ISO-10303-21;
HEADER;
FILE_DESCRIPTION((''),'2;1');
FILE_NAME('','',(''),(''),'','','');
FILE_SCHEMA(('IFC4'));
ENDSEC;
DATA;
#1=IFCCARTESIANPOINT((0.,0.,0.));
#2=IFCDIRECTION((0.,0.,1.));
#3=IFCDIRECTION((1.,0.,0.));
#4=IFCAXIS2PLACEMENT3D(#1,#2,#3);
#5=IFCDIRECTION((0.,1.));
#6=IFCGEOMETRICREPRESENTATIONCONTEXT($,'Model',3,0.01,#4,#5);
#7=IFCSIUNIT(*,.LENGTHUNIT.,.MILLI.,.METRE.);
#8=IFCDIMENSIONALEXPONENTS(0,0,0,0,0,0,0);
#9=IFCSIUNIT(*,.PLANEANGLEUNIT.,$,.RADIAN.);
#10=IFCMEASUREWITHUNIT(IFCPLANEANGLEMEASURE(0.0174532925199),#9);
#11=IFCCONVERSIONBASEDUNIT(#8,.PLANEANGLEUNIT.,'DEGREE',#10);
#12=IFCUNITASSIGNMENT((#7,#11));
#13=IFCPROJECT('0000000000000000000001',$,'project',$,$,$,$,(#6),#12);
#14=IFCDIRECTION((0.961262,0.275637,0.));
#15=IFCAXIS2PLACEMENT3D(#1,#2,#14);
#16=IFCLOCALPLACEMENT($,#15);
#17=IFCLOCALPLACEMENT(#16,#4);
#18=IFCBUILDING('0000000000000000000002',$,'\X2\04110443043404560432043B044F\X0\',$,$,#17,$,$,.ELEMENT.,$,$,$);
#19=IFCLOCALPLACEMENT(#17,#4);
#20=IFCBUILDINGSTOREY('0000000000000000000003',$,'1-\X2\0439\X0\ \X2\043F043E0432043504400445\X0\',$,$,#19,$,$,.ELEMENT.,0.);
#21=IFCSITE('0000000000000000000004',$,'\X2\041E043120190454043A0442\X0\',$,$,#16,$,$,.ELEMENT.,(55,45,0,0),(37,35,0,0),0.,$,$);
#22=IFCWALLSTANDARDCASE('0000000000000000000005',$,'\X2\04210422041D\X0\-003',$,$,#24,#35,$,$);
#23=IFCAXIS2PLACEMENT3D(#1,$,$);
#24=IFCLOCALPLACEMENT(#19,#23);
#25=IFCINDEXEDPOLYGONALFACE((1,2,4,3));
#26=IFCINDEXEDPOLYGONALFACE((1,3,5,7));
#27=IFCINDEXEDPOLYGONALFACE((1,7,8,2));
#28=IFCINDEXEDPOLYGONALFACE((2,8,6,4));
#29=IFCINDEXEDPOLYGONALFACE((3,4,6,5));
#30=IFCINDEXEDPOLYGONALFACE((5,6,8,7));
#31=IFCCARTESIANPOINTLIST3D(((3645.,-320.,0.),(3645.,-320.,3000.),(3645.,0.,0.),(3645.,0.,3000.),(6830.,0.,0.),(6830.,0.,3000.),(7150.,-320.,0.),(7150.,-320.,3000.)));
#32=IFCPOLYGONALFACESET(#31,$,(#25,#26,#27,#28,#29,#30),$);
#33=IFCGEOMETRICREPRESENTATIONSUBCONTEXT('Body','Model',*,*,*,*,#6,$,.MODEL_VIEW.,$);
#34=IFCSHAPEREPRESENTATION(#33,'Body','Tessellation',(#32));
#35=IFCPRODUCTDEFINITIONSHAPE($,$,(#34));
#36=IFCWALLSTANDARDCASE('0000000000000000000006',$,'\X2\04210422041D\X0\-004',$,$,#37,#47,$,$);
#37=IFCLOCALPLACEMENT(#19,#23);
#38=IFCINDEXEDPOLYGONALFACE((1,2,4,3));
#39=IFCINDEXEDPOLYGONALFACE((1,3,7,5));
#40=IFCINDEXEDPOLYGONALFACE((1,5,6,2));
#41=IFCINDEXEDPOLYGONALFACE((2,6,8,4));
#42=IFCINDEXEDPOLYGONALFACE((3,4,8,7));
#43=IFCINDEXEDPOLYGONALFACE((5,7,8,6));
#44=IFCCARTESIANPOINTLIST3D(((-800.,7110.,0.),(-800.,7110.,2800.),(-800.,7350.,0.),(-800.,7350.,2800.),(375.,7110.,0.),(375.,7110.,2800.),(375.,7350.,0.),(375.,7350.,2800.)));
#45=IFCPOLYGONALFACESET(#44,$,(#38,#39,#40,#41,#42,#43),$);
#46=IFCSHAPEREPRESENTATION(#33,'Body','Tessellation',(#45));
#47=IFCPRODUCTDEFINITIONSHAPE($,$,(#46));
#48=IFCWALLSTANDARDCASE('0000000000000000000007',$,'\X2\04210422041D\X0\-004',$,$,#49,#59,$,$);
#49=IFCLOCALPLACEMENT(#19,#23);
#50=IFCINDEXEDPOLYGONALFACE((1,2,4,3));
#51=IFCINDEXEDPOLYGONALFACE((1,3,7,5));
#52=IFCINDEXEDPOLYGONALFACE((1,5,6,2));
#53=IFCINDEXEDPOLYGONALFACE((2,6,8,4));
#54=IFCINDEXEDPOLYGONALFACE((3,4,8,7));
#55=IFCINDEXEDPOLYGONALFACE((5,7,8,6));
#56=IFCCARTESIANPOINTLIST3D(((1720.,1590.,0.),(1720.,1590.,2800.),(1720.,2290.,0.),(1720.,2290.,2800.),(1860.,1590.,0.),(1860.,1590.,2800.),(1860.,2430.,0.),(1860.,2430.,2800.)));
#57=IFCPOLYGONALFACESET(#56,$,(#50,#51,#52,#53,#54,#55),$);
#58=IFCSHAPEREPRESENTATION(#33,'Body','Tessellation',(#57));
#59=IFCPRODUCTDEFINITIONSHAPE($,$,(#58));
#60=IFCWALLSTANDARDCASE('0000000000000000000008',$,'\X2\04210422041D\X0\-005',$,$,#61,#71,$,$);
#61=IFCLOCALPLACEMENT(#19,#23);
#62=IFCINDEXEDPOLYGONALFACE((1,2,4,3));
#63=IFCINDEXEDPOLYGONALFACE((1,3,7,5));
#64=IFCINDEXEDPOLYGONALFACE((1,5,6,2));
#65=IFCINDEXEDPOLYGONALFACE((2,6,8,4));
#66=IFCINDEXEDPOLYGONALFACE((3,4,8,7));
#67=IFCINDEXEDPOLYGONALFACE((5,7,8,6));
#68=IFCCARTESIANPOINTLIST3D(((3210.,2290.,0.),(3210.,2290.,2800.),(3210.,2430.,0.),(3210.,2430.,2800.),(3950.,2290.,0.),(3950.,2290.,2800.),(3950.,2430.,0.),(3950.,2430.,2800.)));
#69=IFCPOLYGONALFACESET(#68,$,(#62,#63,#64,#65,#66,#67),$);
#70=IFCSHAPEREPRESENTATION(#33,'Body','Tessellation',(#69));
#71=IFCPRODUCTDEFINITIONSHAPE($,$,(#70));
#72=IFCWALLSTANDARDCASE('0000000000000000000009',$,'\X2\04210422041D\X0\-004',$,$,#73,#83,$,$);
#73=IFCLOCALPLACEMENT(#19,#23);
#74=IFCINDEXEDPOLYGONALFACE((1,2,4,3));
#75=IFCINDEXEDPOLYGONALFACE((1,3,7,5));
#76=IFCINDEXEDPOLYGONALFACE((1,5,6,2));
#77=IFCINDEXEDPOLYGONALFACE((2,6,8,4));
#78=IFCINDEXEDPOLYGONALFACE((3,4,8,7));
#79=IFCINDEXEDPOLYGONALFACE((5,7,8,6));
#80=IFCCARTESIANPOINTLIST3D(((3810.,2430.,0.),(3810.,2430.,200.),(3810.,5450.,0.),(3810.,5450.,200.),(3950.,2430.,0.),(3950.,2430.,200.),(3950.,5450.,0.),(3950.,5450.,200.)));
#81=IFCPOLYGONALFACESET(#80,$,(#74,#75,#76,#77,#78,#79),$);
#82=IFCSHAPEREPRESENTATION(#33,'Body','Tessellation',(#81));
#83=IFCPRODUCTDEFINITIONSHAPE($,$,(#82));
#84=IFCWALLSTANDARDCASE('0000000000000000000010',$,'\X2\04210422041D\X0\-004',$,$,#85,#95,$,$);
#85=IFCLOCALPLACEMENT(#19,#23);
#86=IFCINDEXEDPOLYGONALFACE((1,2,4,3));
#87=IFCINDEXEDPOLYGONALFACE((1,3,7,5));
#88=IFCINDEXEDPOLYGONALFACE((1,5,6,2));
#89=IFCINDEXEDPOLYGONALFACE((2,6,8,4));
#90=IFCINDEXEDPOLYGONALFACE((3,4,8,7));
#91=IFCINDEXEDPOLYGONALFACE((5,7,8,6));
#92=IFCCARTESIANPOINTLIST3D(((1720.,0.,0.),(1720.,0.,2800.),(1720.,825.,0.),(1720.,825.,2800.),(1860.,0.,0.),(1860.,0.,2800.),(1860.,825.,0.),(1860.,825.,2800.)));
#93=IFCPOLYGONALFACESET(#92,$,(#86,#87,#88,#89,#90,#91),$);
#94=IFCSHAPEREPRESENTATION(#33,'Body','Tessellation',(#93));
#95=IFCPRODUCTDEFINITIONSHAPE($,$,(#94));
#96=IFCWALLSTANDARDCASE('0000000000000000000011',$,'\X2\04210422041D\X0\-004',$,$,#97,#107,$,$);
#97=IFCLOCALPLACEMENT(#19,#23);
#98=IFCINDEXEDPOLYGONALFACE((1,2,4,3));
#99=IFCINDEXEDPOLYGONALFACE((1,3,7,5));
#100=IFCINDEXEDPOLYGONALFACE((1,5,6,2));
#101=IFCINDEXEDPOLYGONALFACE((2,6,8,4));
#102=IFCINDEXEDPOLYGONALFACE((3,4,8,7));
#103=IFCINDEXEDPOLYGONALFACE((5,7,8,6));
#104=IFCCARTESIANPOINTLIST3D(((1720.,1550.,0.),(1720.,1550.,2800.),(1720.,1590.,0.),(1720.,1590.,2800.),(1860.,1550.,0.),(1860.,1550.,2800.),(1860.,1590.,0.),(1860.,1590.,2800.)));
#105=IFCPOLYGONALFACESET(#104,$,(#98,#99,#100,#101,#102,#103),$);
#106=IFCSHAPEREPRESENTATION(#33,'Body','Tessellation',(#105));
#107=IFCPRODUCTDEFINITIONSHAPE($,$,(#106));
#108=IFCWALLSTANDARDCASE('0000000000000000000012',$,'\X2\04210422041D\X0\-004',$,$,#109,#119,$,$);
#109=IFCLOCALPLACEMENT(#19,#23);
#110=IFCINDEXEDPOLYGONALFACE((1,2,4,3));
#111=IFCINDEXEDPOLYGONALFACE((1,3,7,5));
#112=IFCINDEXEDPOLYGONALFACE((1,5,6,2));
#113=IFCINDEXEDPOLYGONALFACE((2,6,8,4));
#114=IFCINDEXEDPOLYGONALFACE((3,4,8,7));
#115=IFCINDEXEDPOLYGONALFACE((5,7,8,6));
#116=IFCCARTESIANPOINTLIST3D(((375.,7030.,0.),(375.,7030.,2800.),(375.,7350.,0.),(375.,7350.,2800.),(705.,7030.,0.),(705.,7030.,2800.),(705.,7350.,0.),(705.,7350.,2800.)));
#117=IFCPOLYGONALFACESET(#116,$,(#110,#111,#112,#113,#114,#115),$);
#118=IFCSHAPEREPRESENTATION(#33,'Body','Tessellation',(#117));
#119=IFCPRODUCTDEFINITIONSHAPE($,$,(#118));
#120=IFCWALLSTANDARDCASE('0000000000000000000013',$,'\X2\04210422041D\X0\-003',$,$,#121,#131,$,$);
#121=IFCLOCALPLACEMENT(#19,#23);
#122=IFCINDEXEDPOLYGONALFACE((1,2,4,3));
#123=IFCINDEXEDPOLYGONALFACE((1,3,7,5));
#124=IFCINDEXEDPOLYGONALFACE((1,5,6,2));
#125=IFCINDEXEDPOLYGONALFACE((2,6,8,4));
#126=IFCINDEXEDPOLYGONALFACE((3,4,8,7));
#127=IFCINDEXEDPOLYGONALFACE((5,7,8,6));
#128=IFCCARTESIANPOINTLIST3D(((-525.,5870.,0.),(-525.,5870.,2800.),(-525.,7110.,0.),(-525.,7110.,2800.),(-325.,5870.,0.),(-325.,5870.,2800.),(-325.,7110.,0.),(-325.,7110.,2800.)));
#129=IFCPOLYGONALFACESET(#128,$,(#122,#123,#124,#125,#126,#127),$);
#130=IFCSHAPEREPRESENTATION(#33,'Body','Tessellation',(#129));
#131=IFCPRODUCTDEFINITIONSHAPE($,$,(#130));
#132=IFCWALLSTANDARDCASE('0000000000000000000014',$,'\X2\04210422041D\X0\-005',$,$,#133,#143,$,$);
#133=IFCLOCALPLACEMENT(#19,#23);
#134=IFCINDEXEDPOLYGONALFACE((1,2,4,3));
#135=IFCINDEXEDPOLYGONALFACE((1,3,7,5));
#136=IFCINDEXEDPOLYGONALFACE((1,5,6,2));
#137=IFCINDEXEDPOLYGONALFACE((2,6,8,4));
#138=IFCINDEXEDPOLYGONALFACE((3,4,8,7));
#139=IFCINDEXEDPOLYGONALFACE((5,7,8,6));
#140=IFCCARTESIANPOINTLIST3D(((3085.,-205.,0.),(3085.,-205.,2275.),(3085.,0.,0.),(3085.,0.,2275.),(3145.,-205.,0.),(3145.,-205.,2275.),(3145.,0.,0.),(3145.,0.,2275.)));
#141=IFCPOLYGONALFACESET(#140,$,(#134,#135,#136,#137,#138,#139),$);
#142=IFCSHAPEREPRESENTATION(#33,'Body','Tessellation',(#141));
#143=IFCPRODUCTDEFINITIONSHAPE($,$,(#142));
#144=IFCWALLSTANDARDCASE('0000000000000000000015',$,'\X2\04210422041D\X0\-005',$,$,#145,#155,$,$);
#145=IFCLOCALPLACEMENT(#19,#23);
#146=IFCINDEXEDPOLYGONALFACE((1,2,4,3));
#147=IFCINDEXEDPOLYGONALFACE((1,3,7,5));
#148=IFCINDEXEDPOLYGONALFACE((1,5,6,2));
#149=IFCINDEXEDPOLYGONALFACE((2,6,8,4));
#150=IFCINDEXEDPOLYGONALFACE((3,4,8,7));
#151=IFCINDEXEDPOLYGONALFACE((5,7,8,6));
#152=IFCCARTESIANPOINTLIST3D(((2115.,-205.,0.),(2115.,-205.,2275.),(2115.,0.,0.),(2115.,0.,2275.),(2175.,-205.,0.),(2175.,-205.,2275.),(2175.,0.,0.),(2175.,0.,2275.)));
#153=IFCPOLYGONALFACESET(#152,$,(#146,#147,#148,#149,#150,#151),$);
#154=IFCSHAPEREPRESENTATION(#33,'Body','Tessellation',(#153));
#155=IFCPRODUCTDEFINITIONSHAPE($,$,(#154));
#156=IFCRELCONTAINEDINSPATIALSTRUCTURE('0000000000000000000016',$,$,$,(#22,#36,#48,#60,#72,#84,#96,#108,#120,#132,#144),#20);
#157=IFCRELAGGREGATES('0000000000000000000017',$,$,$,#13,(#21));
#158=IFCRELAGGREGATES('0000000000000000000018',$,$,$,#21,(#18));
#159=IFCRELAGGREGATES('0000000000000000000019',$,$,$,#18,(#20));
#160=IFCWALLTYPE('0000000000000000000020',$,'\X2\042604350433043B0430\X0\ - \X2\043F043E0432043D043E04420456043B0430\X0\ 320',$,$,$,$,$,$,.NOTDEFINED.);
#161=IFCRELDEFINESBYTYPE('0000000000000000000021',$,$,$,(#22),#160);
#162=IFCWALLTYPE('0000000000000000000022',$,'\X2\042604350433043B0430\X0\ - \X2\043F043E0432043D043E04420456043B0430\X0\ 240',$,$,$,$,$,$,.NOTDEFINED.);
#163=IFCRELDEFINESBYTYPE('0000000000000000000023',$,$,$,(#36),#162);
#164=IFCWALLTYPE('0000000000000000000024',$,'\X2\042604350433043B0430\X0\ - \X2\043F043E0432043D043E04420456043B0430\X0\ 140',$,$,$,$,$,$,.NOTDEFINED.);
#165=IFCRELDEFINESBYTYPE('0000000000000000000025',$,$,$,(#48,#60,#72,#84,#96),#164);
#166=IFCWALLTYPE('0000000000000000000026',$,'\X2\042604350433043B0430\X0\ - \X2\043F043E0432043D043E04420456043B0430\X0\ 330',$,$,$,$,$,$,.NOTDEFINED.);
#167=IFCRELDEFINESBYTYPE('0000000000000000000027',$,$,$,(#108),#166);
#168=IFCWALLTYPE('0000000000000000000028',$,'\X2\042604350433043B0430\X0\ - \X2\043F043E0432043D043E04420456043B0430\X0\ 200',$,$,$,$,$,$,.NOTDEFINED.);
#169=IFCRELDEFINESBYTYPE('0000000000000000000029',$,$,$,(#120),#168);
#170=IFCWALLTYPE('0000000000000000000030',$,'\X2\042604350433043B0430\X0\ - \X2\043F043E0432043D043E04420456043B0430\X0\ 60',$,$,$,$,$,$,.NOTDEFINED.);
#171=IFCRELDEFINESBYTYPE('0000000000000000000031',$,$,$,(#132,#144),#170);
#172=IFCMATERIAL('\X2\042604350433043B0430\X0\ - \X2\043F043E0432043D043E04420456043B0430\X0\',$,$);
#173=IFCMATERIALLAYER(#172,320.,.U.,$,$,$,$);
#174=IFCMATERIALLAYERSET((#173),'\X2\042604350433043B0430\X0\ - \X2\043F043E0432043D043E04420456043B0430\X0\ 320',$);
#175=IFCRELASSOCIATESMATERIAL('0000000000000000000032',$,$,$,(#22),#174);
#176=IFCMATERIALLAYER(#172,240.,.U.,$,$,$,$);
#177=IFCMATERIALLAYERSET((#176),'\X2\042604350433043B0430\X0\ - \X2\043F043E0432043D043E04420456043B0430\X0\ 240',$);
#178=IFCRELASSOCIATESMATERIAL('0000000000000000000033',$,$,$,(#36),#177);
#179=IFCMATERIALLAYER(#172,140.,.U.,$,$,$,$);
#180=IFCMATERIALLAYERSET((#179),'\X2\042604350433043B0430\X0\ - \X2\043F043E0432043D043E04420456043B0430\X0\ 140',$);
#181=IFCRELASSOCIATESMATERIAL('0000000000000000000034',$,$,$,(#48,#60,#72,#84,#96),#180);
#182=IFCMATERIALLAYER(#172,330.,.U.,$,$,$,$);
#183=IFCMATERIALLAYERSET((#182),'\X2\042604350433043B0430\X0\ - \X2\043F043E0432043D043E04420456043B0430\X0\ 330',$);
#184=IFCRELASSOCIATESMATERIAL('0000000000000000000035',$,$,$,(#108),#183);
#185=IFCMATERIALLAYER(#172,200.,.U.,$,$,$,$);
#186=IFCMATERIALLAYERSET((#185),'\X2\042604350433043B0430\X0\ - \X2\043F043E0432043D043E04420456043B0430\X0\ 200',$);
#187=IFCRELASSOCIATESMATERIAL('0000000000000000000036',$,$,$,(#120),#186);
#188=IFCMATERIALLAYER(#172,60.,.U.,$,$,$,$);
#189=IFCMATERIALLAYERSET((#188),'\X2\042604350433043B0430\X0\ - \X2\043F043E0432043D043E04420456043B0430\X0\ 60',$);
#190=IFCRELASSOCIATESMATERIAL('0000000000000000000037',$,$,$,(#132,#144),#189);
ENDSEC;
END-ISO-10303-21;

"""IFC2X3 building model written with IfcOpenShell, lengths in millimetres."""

from ifc_helpers import new_model, entity, si_unit, converted_unit, direction, frame, origin_with_axes, place, context, subcontext, project, spatial, polyline, outline, extrude, material, layer, layer_set, layer_usage, type_object, element, save


model = new_model("IFC2X3")

# Units and contexts
model_context = context("Model", 3, precision=0.01, world=origin_with_axes(), true_north=direction((0.0, 1.0)))
body_context = subcontext(model_context, "Body", "Model", "MODEL_VIEW")
ifc_project = project(units=[si_unit("LENGTHUNIT", "METRE", prefix="MILLI"), converted_unit("PLANEANGLEUNIT", "DEGREE", entity("IfcPlaneAngleMeasure", 0.0174532925199), si_unit("PLANEANGLEUNIT", "RADIAN"), dimensions=[0, 0, 0, 0, 0, 0, 0])], contexts=[model_context])

# Site, building, storey
site_placement = place(None, frame((0.0, 0.0, 0.0), z_axis=(0.0, 0.0, 1.0), x_axis=(0.961262, 0.275637, 0.0)))
site = spatial("IfcSite", under=ifc_project, at=site_placement, Name="Об’єкт", CompositionType="ELEMENT", RefLatitude=(55, 45, 0, 0), RefLongitude=(37, 35, 0, 0), RefElevation=0.0)
building_placement = place(site_placement, origin_with_axes())
building = spatial("IfcBuilding", under=site, at=building_placement, Name="Будівля", CompositionType="ELEMENT")
storey_placement = place(building_placement, origin_with_axes())
storey = spatial("IfcBuildingStorey", under=building, at=storey_placement, Name="1-й поверх", CompositionType="ELEMENT", Elevation=0.0)

# Walls
ifc_material_1 = material(Name="Цегла - повнотіла")
ifc_layer_1 = layer(ifc_material_1, 320.0, ventilated="UNKNOWN")
ifc_layer_set_1 = layer_set([ifc_layer_1], Name="Цегла - повнотіла 320")
wall_type_1 = type_object("IfcWallType", Name="Цегла - повнотіла 320", PredefinedType="NOTDEFINED")
ifc_layer_usage_1 = layer_usage(ifc_layer_set_1, "AXIS2", "POSITIVE", 0.0)
wall_1_placement = place(storey_placement, frame((3645.0, -320.0, 0.0), z_axis=(0.0, 0.0, 1.0), x_axis=(1.0, 0.0, 0.0)))
element("IfcWallStandardCase", 1, at=wall_1_placement, inside=storey, type_object=wall_type_1, material=ifc_layer_usage_1, Name="СТН-003", context=body_context, shape_type="SweptSolid", body=[
    extrude(outline(polyline([(0.0, 0.0), (3505.0, 0.0), (3185.0, 320.0), (0.0, 320.0), (0.0, 0.0)])), origin_with_axes(), (0.0, 0.0, 1.0), 3000.0),
])
ifc_layer_2 = layer(ifc_material_1, 240.0, ventilated="UNKNOWN")
ifc_layer_set_2 = layer_set([ifc_layer_2], Name="Цегла - повнотіла 240")
ifc_layer_usage_2 = layer_usage(ifc_layer_set_2, "AXIS2", "POSITIVE", 0.0)
wall_type_2 = type_object("IfcWallType", Name="Цегла - повнотіла 240", PredefinedType="NOTDEFINED")
wall_2_placement = place(storey_placement, frame((-800.0, 7110.0, 0.0), z_axis=(0.0, 0.0, 1.0), x_axis=(1.0, 0.0, 0.0)))
element("IfcWallStandardCase", 2, at=wall_2_placement, inside=storey, type_object=wall_type_2, material=ifc_layer_usage_2, Name="СТН-004", context=body_context, shape_type="SweptSolid", body=[
    extrude(outline(polyline([(0.0, 0.0), (1175.0, 0.0), (1175.0, 240.0), (0.0, 240.0), (0.0, 0.0)])), origin_with_axes(), (0.0, 0.0, 1.0), 2800.0),
])
ifc_layer_3 = layer(ifc_material_1, 140.0, ventilated="UNKNOWN")
ifc_layer_set_3 = layer_set([ifc_layer_3], Name="Цегла - повнотіла 140")
ifc_layer_usage_3 = layer_usage(ifc_layer_set_3, "AXIS2", "POSITIVE", 0.0)
wall_type_3 = type_object("IfcWallType", Name="Цегла - повнотіла 140", PredefinedType="NOTDEFINED")
wall_3_placement = place(storey_placement, frame((1720.0, 2290.0, 0.0), z_axis=(0.0, 0.0, 1.0), x_axis=(0.0, -1.0, 0.0)))
element("IfcWallStandardCase", 3, at=wall_3_placement, inside=storey, type_object=wall_type_3, material=ifc_layer_usage_3, Name="СТН-004", context=body_context, shape_type="SweptSolid", body=[
    extrude(outline(polyline([(0.0, 0.0), (700.0, 0.0), (700.0, 140.0), (-140.0, 140.0), (0.0, 0.0)])), origin_with_axes(), (0.0, 0.0, 1.0), 2800.0),
])
ifc_layer_usage_4 = layer_usage(ifc_layer_set_3, "AXIS2", "POSITIVE", -140.0)
wall_4_placement = place(storey_placement, frame((3950.0, 2290.0, 0.0), z_axis=(0.0, 0.0, 1.0), x_axis=(-1.0, 0.0, 0.0)))
element("IfcWallStandardCase", 4, at=wall_4_placement, inside=storey, type_object=wall_type_3, material=ifc_layer_usage_4, Name="СТН-005", context=body_context, shape_type="SweptSolid", body=[
    extrude(outline(polyline([(0.0, -140.0), (740.0, -140.0), (740.0, 0.0), (0.0, 0.0), (0.0, -140.0)])), origin_with_axes(), (0.0, 0.0, 1.0), 2800.0),
])
ifc_layer_usage_5 = layer_usage(ifc_layer_set_3, "AXIS2", "POSITIVE", 0.0)
wall_5_placement = place(storey_placement, frame((3950.0, 2430.0, 0.0), z_axis=(0.0, 0.0, 1.0), x_axis=(0.0, 1.0, 0.0)))
element("IfcWallStandardCase", 5, at=wall_5_placement, inside=storey, type_object=wall_type_3, material=ifc_layer_usage_5, Name="СТН-004", context=body_context, shape_type="SweptSolid", body=[
    extrude(outline(polyline([(0.0, 0.0), (3020.0, 0.0), (3020.0, 140.0), (0.0, 140.0), (0.0, 0.0)])), origin_with_axes(), (0.0, 0.0, 1.0), 200.0),
])
ifc_layer_usage_6 = layer_usage(ifc_layer_set_3, "AXIS2", "POSITIVE", 0.0)
wall_6_placement = place(storey_placement, frame((1720.0, 825.0, 0.0), z_axis=(0.0, 0.0, 1.0), x_axis=(0.0, -1.0, 0.0)))
element("IfcWallStandardCase", 6, at=wall_6_placement, inside=storey, type_object=wall_type_3, material=ifc_layer_usage_6, Name="СТН-004", context=body_context, shape_type="SweptSolid", body=[
    extrude(outline(polyline([(0.0, 0.0), (825.0, 0.0), (825.0, 140.0), (0.0, 140.0), (0.0, 0.0)])), origin_with_axes(), (0.0, 0.0, 1.0), 2800.0),
])
ifc_layer_usage_7 = layer_usage(ifc_layer_set_3, "AXIS2", "POSITIVE", 0.0)
wall_7_placement = place(storey_placement, frame((1720.0, 1590.0, 0.0), z_axis=(0.0, 0.0, 1.0), x_axis=(0.0, -1.0, 0.0)))
element("IfcWallStandardCase", 7, at=wall_7_placement, inside=storey, type_object=wall_type_3, material=ifc_layer_usage_7, Name="СТН-004", context=body_context, shape_type="SweptSolid", body=[
    extrude(outline(polyline([(0.0, 0.0), (40.0, 0.0), (40.0, 140.0), (0.0, 140.0), (0.0, 0.0)])), origin_with_axes(), (0.0, 0.0, 1.0), 2800.0),
])
ifc_layer_4 = layer(ifc_material_1, 330.0, ventilated="UNKNOWN")
ifc_layer_set_4 = layer_set([ifc_layer_4], Name="Цегла - повнотіла 330")
ifc_layer_usage_8 = layer_usage(ifc_layer_set_4, "AXIS2", "POSITIVE", 0.0)
wall_type_4 = type_object("IfcWallType", Name="Цегла - повнотіла 330", PredefinedType="NOTDEFINED")
wall_8_placement = place(storey_placement, frame((375.0, 7350.0, 0.0), z_axis=(0.0, 0.0, 1.0), x_axis=(0.0, -1.0, 0.0)))
element("IfcWallStandardCase", 8, at=wall_8_placement, inside=storey, type_object=wall_type_4, material=ifc_layer_usage_8, Name="СТН-004", context=body_context, shape_type="SweptSolid", body=[
    extrude(outline(polyline([(0.0, 0.0), (320.0, 0.0), (320.0, 330.0), (0.0, 330.0), (0.0, 0.0)])), origin_with_axes(), (0.0, 0.0, 1.0), 2800.0),
])
ifc_layer_5 = layer(ifc_material_1, 200.0, ventilated="UNKNOWN")
ifc_layer_set_5 = layer_set([ifc_layer_5], Name="Цегла - повнотіла 200")
ifc_layer_usage_9 = layer_usage(ifc_layer_set_5, "AXIS2", "POSITIVE", 0.0)
wall_type_5 = type_object("IfcWallType", Name="Цегла - повнотіла 200", PredefinedType="NOTDEFINED")
wall_9_placement = place(storey_placement, frame((-325.0, 5870.0, 0.0), z_axis=(0.0, 0.0, 1.0), x_axis=(0.0, 1.0, 0.0)))
element("IfcWallStandardCase", 9, at=wall_9_placement, inside=storey, type_object=wall_type_5, material=ifc_layer_usage_9, Name="СТН-003", context=body_context, shape_type="SweptSolid", body=[
    extrude(outline(polyline([(0.0, 0.0), (1240.0, 0.0), (1240.0, 200.0), (0.0, 200.0), (0.0, 0.0)])), origin_with_axes(), (0.0, 0.0, 1.0), 2800.0),
])
ifc_layer_6 = layer(ifc_material_1, 60.0, ventilated="UNKNOWN")
ifc_layer_set_6 = layer_set([ifc_layer_6], Name="Цегла - повнотіла 60")
ifc_layer_usage_10 = layer_usage(ifc_layer_set_6, "AXIS2", "POSITIVE", -60.0)
wall_type_6 = type_object("IfcWallType", Name="Цегла - повнотіла 60", PredefinedType="NOTDEFINED")
wall_10_placement = place(storey_placement, frame((3145.0, 0.0, 0.0), z_axis=(0.0, 0.0, 1.0), x_axis=(0.0, -1.0, 0.0)))
element("IfcWallStandardCase", 10, at=wall_10_placement, inside=storey, type_object=wall_type_6, material=ifc_layer_usage_10, Name="СТН-005", context=body_context, shape_type="SweptSolid", body=[
    extrude(outline(polyline([(0.0, -60.0), (205.0, -60.0), (205.0, 0.0), (0.0, 0.0), (0.0, -60.0)])), origin_with_axes(), (0.0, 0.0, 1.0), 2275.0),
])
ifc_layer_usage_11 = layer_usage(ifc_layer_set_6, "AXIS2", "POSITIVE", -60.0)
wall_11_placement = place(storey_placement, frame((2175.0, 0.0, 0.0), z_axis=(0.0, 0.0, 1.0), x_axis=(0.0, -1.0, 0.0)))
element("IfcWallStandardCase", 11, at=wall_11_placement, inside=storey, type_object=wall_type_6, material=ifc_layer_usage_11, Name="СТН-005", context=body_context, shape_type="SweptSolid", body=[
    extrude(outline(polyline([(0.0, -60.0), (205.0, -60.0), (205.0, 0.0), (0.0, 0.0), (0.0, -60.0)])), origin_with_axes(), (0.0, 0.0, 1.0), 2275.0),
])

save(model, "model.ifc")
